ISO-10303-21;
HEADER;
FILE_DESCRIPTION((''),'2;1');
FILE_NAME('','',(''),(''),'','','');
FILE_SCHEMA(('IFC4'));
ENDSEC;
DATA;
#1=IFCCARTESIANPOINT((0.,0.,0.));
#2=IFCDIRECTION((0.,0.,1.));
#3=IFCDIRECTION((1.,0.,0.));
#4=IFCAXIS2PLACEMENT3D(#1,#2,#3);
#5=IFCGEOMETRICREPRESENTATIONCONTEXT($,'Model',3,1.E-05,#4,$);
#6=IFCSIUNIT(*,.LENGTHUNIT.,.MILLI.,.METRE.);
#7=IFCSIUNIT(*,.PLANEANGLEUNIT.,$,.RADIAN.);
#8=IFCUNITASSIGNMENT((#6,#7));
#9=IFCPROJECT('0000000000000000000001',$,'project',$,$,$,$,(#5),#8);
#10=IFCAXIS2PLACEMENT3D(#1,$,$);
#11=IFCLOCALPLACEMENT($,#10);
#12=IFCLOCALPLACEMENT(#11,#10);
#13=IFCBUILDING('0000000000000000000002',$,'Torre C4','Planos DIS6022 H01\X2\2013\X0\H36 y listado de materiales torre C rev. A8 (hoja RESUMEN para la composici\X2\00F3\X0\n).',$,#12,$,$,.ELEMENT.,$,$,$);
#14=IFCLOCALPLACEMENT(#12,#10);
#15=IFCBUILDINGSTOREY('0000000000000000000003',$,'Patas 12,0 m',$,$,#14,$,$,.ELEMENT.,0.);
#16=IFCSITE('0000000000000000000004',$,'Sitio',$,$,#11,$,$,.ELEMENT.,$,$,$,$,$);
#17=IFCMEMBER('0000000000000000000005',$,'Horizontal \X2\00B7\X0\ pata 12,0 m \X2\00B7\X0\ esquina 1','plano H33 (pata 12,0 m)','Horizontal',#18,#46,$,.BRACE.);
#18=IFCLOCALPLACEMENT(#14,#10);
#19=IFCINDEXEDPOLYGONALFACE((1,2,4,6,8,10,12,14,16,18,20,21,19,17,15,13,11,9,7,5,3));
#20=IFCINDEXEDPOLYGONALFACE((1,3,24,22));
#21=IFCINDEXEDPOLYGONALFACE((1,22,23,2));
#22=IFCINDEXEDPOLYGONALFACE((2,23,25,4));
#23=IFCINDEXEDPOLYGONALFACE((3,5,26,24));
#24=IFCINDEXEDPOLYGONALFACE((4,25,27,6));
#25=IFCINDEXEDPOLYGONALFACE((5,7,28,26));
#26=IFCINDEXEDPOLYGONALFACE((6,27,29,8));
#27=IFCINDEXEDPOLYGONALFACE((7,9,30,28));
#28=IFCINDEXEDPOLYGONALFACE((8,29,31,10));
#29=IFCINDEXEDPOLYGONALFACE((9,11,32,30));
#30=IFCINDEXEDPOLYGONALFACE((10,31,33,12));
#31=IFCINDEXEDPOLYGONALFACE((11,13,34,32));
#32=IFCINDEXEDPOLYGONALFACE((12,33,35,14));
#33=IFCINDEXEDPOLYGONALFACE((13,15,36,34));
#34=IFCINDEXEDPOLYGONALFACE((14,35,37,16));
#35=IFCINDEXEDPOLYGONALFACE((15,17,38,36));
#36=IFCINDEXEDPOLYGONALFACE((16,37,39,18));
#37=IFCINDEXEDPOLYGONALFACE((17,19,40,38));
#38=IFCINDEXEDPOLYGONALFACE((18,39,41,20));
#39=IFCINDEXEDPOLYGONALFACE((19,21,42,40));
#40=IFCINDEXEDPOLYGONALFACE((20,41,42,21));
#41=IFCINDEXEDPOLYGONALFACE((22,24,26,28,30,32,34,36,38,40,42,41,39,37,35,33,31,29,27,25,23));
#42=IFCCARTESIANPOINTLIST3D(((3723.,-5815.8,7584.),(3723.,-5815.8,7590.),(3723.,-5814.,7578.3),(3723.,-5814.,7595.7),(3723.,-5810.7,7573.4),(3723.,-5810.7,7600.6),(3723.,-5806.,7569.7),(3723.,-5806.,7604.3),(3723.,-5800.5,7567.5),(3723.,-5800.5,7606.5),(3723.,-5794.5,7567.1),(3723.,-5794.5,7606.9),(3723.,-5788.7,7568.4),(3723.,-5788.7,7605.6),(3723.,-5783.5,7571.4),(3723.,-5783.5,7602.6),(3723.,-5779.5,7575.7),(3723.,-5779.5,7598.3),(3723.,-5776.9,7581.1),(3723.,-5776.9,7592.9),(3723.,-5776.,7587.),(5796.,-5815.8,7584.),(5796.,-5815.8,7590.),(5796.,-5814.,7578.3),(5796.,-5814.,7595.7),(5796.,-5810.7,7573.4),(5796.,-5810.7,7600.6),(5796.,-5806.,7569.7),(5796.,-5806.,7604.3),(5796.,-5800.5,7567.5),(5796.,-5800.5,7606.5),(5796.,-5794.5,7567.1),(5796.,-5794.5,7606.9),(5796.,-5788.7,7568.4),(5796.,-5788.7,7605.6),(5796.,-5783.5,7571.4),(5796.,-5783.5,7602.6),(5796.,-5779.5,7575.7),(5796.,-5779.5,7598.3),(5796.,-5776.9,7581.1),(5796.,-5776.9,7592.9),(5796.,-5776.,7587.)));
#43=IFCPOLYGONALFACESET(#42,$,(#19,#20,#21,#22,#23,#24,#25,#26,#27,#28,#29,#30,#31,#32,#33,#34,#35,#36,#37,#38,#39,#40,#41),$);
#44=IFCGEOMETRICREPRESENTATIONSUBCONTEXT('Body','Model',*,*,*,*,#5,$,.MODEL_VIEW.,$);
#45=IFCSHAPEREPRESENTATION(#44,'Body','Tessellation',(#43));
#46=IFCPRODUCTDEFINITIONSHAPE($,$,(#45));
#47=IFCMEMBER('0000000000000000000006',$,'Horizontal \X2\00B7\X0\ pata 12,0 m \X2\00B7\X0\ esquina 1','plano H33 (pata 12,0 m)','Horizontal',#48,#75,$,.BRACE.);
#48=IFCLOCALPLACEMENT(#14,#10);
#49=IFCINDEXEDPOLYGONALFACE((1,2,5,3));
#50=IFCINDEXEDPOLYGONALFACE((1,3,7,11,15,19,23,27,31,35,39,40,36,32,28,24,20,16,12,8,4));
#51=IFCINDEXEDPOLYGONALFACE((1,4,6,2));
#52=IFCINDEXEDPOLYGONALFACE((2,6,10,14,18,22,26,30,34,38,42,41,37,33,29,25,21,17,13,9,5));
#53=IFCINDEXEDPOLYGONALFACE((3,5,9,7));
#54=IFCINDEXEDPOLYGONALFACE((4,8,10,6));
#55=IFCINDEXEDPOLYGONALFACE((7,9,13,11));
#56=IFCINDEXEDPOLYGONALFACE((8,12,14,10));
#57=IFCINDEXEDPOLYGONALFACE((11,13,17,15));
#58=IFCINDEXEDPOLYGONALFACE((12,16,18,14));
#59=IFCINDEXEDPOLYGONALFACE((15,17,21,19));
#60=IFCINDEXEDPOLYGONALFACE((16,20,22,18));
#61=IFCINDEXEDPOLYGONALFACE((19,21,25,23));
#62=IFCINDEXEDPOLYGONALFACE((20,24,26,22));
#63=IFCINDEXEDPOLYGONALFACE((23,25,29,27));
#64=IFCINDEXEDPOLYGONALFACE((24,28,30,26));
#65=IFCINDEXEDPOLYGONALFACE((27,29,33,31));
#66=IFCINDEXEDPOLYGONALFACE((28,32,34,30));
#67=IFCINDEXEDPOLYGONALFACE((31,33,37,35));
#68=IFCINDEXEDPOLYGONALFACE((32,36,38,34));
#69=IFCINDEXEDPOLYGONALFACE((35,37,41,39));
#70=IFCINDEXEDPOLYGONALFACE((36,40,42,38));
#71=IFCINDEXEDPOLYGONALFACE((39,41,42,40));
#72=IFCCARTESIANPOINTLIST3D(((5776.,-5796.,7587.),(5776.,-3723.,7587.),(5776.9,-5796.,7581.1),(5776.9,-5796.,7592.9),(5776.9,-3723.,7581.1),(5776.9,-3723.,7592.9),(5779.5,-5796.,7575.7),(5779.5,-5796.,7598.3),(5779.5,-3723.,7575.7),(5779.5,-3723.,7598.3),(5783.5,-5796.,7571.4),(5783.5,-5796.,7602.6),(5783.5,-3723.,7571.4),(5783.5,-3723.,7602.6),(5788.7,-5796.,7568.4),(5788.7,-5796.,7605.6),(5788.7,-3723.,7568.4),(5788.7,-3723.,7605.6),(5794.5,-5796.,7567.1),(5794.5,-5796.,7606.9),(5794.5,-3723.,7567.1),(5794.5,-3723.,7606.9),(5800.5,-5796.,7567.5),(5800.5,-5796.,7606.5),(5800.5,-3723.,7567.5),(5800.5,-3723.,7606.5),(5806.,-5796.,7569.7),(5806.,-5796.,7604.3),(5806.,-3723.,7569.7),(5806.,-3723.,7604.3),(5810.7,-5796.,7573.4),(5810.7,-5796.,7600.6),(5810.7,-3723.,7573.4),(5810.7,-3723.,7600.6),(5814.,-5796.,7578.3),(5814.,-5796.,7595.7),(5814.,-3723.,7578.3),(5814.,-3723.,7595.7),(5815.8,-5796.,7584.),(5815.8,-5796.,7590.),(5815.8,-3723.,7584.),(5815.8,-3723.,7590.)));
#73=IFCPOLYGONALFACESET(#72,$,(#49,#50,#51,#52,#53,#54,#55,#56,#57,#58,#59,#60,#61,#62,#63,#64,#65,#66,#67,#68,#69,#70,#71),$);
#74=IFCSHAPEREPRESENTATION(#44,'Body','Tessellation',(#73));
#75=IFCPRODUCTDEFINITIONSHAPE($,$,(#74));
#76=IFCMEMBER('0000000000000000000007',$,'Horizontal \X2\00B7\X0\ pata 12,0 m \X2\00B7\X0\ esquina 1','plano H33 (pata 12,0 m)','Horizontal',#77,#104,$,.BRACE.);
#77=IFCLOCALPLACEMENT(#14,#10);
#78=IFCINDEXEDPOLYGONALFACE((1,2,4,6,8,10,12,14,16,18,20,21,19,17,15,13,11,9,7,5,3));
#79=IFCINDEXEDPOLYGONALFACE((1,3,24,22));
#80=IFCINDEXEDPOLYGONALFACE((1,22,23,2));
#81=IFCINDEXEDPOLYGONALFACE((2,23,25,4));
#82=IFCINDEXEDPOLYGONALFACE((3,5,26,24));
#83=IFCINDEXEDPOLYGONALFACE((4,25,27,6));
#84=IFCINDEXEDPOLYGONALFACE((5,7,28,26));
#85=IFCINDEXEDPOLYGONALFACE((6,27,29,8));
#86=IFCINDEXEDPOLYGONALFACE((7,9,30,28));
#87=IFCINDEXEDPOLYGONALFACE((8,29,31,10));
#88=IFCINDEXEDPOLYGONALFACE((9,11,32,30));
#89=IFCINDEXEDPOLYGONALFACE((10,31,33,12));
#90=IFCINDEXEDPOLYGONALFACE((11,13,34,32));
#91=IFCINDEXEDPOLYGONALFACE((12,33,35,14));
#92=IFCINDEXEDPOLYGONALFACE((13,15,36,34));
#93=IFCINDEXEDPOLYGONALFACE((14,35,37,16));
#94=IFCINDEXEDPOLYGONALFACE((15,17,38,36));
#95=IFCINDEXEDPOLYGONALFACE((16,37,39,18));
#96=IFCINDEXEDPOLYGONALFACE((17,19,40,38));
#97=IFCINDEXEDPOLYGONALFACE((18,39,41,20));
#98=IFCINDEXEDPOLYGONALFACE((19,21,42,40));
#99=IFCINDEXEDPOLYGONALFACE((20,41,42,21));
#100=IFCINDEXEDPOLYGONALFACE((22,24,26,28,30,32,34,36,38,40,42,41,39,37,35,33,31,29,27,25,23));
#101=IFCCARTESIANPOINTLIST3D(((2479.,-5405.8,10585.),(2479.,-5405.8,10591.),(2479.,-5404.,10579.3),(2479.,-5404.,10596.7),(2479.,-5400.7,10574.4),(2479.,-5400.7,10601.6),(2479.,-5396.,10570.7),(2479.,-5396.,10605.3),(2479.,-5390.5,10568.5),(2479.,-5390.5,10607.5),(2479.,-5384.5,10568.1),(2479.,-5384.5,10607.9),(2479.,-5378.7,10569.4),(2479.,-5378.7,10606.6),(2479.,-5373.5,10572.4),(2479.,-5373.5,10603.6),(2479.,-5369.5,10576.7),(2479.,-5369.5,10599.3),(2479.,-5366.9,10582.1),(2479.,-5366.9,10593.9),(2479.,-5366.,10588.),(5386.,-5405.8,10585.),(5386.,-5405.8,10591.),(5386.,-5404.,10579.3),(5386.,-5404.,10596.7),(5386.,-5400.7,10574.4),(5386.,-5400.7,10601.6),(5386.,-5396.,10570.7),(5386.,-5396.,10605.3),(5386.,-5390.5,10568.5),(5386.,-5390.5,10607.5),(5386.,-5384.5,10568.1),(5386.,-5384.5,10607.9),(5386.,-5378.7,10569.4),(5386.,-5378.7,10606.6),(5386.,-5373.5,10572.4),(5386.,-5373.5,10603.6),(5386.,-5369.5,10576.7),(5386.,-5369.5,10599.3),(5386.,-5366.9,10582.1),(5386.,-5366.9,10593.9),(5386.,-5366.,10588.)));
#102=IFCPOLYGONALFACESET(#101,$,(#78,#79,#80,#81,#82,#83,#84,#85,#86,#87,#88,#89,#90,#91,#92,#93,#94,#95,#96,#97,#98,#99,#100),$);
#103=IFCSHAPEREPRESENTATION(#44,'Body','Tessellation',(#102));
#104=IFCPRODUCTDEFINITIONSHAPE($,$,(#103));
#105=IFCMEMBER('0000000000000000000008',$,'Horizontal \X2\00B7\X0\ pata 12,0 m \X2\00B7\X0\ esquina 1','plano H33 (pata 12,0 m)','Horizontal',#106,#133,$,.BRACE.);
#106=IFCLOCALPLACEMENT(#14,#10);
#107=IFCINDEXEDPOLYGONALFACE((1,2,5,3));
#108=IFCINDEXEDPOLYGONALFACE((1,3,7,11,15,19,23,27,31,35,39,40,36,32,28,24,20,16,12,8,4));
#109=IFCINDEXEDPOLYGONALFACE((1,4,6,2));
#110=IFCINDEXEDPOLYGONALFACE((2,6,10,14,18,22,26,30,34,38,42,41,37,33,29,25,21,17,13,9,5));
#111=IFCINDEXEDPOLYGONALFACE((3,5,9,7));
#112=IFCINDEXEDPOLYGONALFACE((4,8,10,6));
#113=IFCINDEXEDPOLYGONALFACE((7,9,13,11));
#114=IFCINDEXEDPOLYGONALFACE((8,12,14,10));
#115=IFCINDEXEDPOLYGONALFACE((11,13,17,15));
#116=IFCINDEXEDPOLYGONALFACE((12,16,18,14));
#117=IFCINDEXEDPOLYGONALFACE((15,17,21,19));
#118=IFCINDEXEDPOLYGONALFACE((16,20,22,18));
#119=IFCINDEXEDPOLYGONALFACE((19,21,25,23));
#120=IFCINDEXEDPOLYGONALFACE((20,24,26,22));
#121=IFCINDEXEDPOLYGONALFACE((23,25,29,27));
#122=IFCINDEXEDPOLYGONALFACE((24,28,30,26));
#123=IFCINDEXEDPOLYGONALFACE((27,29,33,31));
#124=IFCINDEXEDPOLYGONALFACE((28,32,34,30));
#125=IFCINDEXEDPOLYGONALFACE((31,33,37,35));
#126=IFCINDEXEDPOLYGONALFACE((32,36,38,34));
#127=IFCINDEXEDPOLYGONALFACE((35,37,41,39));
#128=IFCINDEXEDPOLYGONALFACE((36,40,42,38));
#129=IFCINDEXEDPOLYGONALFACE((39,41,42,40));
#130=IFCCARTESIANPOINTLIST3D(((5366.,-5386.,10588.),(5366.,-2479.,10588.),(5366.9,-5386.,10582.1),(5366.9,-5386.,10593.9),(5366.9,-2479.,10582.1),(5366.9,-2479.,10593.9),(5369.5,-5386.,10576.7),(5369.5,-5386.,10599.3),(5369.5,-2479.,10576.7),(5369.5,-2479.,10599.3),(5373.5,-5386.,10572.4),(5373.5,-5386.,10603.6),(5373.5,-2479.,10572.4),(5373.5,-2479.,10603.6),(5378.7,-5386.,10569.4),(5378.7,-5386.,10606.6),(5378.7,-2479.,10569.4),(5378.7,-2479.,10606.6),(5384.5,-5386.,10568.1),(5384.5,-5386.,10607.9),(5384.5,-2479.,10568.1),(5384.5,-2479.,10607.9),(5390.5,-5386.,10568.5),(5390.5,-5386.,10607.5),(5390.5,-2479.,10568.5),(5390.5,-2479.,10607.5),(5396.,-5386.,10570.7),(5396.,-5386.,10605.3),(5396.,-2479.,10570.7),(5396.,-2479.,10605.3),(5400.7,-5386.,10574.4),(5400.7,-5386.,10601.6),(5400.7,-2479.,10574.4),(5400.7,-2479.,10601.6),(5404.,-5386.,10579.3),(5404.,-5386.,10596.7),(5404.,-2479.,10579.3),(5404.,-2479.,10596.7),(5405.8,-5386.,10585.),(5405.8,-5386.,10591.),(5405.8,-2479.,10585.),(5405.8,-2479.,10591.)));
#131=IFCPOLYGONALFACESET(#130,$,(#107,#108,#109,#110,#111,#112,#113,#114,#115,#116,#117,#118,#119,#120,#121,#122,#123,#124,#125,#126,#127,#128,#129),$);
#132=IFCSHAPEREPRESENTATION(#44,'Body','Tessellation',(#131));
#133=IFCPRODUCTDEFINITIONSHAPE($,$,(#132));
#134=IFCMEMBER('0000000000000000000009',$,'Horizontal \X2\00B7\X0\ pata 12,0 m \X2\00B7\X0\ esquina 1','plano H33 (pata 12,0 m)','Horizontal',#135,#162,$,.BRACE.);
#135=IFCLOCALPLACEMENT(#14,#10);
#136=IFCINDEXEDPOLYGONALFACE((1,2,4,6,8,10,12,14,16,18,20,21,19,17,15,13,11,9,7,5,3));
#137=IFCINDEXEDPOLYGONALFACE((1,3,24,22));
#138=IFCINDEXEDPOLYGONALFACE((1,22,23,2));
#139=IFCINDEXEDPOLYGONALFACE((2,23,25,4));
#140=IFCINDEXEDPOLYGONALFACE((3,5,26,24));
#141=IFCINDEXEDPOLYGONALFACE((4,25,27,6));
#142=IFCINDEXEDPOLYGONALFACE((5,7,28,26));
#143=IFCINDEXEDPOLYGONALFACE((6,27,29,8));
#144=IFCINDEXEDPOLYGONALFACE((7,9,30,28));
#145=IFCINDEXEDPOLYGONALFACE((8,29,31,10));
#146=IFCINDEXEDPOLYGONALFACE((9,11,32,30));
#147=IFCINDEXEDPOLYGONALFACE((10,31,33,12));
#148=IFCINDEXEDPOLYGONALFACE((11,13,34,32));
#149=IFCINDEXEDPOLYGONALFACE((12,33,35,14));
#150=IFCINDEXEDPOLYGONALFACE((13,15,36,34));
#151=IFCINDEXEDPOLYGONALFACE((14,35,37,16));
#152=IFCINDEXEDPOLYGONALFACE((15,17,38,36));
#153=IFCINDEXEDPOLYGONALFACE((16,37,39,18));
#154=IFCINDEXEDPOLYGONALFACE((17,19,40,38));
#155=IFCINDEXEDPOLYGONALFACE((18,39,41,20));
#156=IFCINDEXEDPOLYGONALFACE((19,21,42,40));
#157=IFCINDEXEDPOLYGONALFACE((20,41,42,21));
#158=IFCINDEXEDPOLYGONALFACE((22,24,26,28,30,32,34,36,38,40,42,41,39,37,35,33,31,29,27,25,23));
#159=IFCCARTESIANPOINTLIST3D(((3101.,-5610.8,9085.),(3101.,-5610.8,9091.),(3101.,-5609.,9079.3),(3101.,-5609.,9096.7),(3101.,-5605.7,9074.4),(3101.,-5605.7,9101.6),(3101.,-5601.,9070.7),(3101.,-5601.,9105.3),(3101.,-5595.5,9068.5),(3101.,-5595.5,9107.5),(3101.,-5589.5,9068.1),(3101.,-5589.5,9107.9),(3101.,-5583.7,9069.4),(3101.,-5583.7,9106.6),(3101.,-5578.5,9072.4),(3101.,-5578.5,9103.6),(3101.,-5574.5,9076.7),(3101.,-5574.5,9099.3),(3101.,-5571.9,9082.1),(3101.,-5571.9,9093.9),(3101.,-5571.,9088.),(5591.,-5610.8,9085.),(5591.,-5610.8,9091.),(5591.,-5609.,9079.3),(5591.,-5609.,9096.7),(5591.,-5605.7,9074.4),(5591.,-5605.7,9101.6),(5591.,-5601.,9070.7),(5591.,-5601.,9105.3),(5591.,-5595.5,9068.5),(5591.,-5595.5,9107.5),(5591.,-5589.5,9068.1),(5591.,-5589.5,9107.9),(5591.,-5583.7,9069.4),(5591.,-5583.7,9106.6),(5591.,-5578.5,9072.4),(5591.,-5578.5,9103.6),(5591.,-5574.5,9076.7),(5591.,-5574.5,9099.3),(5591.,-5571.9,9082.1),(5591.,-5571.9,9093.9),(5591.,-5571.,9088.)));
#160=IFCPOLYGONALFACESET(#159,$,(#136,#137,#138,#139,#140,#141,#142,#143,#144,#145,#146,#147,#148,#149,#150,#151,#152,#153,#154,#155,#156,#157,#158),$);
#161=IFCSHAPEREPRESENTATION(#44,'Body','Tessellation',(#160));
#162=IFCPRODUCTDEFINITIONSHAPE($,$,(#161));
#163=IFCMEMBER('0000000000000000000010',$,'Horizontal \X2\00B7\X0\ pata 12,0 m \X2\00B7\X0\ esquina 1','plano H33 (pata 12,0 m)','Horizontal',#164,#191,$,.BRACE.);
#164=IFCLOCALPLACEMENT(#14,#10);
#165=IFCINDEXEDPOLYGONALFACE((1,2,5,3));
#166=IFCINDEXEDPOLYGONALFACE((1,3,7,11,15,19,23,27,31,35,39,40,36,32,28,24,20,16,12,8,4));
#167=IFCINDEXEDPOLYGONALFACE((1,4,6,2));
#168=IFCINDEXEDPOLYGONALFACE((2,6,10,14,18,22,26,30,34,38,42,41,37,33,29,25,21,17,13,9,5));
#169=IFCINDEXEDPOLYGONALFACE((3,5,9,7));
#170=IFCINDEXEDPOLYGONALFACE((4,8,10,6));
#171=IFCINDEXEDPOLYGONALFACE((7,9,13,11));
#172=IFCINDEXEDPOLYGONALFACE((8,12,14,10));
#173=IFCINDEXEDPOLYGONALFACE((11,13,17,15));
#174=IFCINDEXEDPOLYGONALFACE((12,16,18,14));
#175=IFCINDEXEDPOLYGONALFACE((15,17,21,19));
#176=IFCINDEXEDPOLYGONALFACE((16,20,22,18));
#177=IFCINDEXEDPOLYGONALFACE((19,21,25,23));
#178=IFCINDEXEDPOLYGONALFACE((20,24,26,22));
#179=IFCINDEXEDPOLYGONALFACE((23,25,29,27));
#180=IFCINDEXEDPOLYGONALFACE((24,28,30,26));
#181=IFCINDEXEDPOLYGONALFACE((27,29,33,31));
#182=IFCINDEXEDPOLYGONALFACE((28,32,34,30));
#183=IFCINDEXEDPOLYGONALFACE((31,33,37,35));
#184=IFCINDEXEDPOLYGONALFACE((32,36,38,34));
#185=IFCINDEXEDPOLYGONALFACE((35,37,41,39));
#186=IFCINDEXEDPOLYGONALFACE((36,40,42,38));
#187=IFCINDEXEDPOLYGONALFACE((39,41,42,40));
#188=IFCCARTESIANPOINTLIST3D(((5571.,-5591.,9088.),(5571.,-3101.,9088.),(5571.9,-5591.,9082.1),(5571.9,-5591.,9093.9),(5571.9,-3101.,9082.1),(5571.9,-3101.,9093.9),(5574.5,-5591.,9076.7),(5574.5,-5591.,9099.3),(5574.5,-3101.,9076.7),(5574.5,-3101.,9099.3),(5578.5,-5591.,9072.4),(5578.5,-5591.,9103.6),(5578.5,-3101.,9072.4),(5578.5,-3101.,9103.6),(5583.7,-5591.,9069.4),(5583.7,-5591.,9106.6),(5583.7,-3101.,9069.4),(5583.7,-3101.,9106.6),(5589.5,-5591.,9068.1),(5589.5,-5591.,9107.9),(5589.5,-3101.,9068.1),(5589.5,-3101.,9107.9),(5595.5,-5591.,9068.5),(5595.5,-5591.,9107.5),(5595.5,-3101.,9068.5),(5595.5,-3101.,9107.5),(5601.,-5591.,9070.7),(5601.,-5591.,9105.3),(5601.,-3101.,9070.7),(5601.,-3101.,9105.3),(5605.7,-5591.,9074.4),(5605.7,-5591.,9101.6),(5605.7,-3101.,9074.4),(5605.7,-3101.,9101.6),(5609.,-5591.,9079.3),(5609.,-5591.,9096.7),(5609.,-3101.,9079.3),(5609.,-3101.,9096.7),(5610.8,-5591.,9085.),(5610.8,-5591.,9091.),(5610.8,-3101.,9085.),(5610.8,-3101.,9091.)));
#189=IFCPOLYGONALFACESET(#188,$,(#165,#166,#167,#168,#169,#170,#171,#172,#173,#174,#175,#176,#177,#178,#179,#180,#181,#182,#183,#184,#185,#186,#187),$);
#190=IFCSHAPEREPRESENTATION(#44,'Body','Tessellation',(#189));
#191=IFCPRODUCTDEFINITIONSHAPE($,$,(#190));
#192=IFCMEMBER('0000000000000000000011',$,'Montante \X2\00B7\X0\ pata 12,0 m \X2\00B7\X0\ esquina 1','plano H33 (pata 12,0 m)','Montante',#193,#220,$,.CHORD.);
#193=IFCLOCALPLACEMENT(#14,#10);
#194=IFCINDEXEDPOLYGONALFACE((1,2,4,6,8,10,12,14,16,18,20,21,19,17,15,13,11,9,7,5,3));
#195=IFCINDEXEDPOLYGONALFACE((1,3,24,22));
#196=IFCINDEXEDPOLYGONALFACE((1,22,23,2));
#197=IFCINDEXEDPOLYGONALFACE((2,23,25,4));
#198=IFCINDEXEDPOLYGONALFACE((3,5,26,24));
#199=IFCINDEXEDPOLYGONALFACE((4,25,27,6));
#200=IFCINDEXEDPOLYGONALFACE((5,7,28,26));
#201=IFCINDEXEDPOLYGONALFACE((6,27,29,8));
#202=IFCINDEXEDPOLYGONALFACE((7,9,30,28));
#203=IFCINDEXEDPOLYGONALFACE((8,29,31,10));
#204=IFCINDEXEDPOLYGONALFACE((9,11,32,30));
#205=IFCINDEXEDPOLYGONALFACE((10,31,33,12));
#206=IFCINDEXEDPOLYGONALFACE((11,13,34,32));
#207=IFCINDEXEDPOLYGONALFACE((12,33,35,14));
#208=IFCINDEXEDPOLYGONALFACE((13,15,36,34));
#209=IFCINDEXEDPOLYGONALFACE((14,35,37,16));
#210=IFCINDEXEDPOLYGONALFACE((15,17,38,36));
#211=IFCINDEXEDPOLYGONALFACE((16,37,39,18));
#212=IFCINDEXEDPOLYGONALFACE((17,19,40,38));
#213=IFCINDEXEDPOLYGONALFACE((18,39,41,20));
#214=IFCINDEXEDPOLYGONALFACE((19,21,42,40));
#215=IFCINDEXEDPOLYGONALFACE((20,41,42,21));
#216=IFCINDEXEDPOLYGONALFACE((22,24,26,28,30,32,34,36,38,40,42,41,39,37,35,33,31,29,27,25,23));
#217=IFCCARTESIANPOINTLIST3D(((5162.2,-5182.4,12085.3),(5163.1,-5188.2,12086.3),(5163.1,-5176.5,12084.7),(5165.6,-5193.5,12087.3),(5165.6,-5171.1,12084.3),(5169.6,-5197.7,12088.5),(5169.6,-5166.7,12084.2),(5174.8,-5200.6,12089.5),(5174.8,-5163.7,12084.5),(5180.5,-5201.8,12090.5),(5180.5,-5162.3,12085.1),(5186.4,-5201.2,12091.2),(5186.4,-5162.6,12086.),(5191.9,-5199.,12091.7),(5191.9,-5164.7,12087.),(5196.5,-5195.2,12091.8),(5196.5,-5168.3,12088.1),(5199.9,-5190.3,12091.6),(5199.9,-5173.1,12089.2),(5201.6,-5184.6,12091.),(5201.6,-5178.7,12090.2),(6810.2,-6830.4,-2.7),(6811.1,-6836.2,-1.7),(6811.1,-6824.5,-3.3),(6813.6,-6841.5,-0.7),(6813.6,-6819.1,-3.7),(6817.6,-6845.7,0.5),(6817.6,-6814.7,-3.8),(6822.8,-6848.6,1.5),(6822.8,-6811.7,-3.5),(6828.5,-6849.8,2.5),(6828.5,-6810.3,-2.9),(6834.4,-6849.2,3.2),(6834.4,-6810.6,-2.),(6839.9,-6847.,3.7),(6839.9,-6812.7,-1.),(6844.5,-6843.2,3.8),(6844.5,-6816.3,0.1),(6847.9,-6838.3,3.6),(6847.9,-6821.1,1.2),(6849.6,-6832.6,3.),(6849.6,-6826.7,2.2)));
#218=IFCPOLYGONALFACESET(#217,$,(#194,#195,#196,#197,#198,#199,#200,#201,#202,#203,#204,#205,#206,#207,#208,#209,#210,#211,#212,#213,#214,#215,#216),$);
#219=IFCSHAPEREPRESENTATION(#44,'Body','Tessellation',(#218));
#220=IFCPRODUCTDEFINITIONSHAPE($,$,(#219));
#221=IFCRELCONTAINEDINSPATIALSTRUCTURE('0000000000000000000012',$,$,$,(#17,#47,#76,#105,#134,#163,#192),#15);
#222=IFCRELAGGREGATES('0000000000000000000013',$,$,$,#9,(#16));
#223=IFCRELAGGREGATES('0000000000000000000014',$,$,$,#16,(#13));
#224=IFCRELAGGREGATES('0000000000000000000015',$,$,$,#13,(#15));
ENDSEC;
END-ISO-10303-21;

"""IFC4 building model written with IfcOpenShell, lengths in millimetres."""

from ifc_helpers import new_model, si_unit, frame, origin, origin_with_axes, place, context, subcontext, project, spatial, circle, extrude, element, save


model = new_model("IFC4")

# Units and contexts
model_context = context("Model", 3, precision=1e-05, world=origin_with_axes())
body_context = subcontext(model_context, "Body", "Model", "MODEL_VIEW")
ifc_project = project(units=[si_unit("LENGTHUNIT", "METRE", prefix="MILLI"), si_unit("PLANEANGLEUNIT", "RADIAN")], contexts=[model_context])

# Site, building, storey
site_placement = place(None, origin())
site = spatial("IfcSite", under=ifc_project, at=site_placement, Name="Sitio", CompositionType="ELEMENT")
building_placement = place(site_placement, origin())
building = spatial("IfcBuilding", under=site, at=building_placement, Name="Torre C4", Description="Planos DIS6022 H01–H36 y listado de materiales torre C rev. A8 (hoja RESUMEN para la composición).", CompositionType="ELEMENT")
storey_placement = place(building_placement, origin())
storey = spatial("IfcBuildingStorey", under=building, at=storey_placement, Name="Patas 12,0 m", CompositionType="ELEMENT", Elevation=0.0)

# Members
for number, where, z_axis, x_axis, name in (
    (1, (3723.0, -5796.0, 7587.0), (1.0, 0.0, 0.0), (0.0, 1.0, 0.0), "Horizontal · pata 12,0 m · esquina 1"),
    (2, (5796.0, -3723.0, 7587.0), (0.0, -1.0, 0.0), (-1.0, 0.0, 0.0), "Horizontal · pata 12,0 m · esquina 1"),
):
    element("IfcMember", number, at=place(storey_placement, frame(where, z_axis=z_axis, x_axis=x_axis)), inside=storey, Name=name, Description="plano H33 (pata 12,0 m)", ObjectType="Horizontal", PredefinedType="BRACE", context=body_context, shape_type="SweptSolid", body=[
        extrude(circle(Radius=20.0), None, (0.0, 0.0, 1.0), 2073.0),
    ])
for number, where, z_axis, x_axis, name in (
    (3, (5386.0, -5386.0, 10588.0), (-1.0, 0.0, 0.0), (0.0, 1.0, 0.0), "Horizontal · pata 12,0 m · esquina 1"),
    (4, (5386.0, -5386.0, 10588.0), (0.0, 1.0, 0.0), (-1.0, 0.0, 0.0), "Horizontal · pata 12,0 m · esquina 1"),
):
    element("IfcMember", number, at=place(storey_placement, frame(where, z_axis=z_axis, x_axis=x_axis)), inside=storey, Name=name, Description="plano H33 (pata 12,0 m)", ObjectType="Horizontal", PredefinedType="BRACE", context=body_context, shape_type="SweptSolid", body=[
        extrude(circle(Radius=20.0), None, (0.0, 0.0, 1.0), 2907.0),
    ])
for number, where, z_axis, x_axis, name in (
    (5, (5591.0, -5591.0, 9088.0), (-1.0, 0.0, 0.0), (0.0, 1.0, 0.0), "Horizontal · pata 12,0 m · esquina 1"),
    (6, (5591.0, -5591.0, 9088.0), (0.0, 1.0, 0.0), (-1.0, 0.0, 0.0), "Horizontal · pata 12,0 m · esquina 1"),
):
    element("IfcMember", number, at=place(storey_placement, frame(where, z_axis=z_axis, x_axis=x_axis)), inside=storey, Name=name, Description="plano H33 (pata 12,0 m)", ObjectType="Horizontal", PredefinedType="BRACE", context=body_context, shape_type="SweptSolid", body=[
        extrude(circle(Radius=20.0), None, (0.0, 0.0, 1.0), 2490.0),
    ])
member_1_placement = place(storey_placement, frame((5182.0, -5182.0, 12088.0), z_axis=(0.133868, -0.133868, -0.981916), x_axis=(-0.990999, -0.018083, -0.132641)))
element("IfcMember", 7, at=member_1_placement, inside=storey, Name="Montante · pata 12,0 m · esquina 1", Description="plano H33 (pata 12,0 m)", ObjectType="Montante", PredefinedType="CHORD", context=body_context, shape_type="SweptSolid", body=[
    extrude(circle(Radius=20.0), None, (0.0, 0.0, 1.0), 12310.6),
])

save(model, "model.ifc")
